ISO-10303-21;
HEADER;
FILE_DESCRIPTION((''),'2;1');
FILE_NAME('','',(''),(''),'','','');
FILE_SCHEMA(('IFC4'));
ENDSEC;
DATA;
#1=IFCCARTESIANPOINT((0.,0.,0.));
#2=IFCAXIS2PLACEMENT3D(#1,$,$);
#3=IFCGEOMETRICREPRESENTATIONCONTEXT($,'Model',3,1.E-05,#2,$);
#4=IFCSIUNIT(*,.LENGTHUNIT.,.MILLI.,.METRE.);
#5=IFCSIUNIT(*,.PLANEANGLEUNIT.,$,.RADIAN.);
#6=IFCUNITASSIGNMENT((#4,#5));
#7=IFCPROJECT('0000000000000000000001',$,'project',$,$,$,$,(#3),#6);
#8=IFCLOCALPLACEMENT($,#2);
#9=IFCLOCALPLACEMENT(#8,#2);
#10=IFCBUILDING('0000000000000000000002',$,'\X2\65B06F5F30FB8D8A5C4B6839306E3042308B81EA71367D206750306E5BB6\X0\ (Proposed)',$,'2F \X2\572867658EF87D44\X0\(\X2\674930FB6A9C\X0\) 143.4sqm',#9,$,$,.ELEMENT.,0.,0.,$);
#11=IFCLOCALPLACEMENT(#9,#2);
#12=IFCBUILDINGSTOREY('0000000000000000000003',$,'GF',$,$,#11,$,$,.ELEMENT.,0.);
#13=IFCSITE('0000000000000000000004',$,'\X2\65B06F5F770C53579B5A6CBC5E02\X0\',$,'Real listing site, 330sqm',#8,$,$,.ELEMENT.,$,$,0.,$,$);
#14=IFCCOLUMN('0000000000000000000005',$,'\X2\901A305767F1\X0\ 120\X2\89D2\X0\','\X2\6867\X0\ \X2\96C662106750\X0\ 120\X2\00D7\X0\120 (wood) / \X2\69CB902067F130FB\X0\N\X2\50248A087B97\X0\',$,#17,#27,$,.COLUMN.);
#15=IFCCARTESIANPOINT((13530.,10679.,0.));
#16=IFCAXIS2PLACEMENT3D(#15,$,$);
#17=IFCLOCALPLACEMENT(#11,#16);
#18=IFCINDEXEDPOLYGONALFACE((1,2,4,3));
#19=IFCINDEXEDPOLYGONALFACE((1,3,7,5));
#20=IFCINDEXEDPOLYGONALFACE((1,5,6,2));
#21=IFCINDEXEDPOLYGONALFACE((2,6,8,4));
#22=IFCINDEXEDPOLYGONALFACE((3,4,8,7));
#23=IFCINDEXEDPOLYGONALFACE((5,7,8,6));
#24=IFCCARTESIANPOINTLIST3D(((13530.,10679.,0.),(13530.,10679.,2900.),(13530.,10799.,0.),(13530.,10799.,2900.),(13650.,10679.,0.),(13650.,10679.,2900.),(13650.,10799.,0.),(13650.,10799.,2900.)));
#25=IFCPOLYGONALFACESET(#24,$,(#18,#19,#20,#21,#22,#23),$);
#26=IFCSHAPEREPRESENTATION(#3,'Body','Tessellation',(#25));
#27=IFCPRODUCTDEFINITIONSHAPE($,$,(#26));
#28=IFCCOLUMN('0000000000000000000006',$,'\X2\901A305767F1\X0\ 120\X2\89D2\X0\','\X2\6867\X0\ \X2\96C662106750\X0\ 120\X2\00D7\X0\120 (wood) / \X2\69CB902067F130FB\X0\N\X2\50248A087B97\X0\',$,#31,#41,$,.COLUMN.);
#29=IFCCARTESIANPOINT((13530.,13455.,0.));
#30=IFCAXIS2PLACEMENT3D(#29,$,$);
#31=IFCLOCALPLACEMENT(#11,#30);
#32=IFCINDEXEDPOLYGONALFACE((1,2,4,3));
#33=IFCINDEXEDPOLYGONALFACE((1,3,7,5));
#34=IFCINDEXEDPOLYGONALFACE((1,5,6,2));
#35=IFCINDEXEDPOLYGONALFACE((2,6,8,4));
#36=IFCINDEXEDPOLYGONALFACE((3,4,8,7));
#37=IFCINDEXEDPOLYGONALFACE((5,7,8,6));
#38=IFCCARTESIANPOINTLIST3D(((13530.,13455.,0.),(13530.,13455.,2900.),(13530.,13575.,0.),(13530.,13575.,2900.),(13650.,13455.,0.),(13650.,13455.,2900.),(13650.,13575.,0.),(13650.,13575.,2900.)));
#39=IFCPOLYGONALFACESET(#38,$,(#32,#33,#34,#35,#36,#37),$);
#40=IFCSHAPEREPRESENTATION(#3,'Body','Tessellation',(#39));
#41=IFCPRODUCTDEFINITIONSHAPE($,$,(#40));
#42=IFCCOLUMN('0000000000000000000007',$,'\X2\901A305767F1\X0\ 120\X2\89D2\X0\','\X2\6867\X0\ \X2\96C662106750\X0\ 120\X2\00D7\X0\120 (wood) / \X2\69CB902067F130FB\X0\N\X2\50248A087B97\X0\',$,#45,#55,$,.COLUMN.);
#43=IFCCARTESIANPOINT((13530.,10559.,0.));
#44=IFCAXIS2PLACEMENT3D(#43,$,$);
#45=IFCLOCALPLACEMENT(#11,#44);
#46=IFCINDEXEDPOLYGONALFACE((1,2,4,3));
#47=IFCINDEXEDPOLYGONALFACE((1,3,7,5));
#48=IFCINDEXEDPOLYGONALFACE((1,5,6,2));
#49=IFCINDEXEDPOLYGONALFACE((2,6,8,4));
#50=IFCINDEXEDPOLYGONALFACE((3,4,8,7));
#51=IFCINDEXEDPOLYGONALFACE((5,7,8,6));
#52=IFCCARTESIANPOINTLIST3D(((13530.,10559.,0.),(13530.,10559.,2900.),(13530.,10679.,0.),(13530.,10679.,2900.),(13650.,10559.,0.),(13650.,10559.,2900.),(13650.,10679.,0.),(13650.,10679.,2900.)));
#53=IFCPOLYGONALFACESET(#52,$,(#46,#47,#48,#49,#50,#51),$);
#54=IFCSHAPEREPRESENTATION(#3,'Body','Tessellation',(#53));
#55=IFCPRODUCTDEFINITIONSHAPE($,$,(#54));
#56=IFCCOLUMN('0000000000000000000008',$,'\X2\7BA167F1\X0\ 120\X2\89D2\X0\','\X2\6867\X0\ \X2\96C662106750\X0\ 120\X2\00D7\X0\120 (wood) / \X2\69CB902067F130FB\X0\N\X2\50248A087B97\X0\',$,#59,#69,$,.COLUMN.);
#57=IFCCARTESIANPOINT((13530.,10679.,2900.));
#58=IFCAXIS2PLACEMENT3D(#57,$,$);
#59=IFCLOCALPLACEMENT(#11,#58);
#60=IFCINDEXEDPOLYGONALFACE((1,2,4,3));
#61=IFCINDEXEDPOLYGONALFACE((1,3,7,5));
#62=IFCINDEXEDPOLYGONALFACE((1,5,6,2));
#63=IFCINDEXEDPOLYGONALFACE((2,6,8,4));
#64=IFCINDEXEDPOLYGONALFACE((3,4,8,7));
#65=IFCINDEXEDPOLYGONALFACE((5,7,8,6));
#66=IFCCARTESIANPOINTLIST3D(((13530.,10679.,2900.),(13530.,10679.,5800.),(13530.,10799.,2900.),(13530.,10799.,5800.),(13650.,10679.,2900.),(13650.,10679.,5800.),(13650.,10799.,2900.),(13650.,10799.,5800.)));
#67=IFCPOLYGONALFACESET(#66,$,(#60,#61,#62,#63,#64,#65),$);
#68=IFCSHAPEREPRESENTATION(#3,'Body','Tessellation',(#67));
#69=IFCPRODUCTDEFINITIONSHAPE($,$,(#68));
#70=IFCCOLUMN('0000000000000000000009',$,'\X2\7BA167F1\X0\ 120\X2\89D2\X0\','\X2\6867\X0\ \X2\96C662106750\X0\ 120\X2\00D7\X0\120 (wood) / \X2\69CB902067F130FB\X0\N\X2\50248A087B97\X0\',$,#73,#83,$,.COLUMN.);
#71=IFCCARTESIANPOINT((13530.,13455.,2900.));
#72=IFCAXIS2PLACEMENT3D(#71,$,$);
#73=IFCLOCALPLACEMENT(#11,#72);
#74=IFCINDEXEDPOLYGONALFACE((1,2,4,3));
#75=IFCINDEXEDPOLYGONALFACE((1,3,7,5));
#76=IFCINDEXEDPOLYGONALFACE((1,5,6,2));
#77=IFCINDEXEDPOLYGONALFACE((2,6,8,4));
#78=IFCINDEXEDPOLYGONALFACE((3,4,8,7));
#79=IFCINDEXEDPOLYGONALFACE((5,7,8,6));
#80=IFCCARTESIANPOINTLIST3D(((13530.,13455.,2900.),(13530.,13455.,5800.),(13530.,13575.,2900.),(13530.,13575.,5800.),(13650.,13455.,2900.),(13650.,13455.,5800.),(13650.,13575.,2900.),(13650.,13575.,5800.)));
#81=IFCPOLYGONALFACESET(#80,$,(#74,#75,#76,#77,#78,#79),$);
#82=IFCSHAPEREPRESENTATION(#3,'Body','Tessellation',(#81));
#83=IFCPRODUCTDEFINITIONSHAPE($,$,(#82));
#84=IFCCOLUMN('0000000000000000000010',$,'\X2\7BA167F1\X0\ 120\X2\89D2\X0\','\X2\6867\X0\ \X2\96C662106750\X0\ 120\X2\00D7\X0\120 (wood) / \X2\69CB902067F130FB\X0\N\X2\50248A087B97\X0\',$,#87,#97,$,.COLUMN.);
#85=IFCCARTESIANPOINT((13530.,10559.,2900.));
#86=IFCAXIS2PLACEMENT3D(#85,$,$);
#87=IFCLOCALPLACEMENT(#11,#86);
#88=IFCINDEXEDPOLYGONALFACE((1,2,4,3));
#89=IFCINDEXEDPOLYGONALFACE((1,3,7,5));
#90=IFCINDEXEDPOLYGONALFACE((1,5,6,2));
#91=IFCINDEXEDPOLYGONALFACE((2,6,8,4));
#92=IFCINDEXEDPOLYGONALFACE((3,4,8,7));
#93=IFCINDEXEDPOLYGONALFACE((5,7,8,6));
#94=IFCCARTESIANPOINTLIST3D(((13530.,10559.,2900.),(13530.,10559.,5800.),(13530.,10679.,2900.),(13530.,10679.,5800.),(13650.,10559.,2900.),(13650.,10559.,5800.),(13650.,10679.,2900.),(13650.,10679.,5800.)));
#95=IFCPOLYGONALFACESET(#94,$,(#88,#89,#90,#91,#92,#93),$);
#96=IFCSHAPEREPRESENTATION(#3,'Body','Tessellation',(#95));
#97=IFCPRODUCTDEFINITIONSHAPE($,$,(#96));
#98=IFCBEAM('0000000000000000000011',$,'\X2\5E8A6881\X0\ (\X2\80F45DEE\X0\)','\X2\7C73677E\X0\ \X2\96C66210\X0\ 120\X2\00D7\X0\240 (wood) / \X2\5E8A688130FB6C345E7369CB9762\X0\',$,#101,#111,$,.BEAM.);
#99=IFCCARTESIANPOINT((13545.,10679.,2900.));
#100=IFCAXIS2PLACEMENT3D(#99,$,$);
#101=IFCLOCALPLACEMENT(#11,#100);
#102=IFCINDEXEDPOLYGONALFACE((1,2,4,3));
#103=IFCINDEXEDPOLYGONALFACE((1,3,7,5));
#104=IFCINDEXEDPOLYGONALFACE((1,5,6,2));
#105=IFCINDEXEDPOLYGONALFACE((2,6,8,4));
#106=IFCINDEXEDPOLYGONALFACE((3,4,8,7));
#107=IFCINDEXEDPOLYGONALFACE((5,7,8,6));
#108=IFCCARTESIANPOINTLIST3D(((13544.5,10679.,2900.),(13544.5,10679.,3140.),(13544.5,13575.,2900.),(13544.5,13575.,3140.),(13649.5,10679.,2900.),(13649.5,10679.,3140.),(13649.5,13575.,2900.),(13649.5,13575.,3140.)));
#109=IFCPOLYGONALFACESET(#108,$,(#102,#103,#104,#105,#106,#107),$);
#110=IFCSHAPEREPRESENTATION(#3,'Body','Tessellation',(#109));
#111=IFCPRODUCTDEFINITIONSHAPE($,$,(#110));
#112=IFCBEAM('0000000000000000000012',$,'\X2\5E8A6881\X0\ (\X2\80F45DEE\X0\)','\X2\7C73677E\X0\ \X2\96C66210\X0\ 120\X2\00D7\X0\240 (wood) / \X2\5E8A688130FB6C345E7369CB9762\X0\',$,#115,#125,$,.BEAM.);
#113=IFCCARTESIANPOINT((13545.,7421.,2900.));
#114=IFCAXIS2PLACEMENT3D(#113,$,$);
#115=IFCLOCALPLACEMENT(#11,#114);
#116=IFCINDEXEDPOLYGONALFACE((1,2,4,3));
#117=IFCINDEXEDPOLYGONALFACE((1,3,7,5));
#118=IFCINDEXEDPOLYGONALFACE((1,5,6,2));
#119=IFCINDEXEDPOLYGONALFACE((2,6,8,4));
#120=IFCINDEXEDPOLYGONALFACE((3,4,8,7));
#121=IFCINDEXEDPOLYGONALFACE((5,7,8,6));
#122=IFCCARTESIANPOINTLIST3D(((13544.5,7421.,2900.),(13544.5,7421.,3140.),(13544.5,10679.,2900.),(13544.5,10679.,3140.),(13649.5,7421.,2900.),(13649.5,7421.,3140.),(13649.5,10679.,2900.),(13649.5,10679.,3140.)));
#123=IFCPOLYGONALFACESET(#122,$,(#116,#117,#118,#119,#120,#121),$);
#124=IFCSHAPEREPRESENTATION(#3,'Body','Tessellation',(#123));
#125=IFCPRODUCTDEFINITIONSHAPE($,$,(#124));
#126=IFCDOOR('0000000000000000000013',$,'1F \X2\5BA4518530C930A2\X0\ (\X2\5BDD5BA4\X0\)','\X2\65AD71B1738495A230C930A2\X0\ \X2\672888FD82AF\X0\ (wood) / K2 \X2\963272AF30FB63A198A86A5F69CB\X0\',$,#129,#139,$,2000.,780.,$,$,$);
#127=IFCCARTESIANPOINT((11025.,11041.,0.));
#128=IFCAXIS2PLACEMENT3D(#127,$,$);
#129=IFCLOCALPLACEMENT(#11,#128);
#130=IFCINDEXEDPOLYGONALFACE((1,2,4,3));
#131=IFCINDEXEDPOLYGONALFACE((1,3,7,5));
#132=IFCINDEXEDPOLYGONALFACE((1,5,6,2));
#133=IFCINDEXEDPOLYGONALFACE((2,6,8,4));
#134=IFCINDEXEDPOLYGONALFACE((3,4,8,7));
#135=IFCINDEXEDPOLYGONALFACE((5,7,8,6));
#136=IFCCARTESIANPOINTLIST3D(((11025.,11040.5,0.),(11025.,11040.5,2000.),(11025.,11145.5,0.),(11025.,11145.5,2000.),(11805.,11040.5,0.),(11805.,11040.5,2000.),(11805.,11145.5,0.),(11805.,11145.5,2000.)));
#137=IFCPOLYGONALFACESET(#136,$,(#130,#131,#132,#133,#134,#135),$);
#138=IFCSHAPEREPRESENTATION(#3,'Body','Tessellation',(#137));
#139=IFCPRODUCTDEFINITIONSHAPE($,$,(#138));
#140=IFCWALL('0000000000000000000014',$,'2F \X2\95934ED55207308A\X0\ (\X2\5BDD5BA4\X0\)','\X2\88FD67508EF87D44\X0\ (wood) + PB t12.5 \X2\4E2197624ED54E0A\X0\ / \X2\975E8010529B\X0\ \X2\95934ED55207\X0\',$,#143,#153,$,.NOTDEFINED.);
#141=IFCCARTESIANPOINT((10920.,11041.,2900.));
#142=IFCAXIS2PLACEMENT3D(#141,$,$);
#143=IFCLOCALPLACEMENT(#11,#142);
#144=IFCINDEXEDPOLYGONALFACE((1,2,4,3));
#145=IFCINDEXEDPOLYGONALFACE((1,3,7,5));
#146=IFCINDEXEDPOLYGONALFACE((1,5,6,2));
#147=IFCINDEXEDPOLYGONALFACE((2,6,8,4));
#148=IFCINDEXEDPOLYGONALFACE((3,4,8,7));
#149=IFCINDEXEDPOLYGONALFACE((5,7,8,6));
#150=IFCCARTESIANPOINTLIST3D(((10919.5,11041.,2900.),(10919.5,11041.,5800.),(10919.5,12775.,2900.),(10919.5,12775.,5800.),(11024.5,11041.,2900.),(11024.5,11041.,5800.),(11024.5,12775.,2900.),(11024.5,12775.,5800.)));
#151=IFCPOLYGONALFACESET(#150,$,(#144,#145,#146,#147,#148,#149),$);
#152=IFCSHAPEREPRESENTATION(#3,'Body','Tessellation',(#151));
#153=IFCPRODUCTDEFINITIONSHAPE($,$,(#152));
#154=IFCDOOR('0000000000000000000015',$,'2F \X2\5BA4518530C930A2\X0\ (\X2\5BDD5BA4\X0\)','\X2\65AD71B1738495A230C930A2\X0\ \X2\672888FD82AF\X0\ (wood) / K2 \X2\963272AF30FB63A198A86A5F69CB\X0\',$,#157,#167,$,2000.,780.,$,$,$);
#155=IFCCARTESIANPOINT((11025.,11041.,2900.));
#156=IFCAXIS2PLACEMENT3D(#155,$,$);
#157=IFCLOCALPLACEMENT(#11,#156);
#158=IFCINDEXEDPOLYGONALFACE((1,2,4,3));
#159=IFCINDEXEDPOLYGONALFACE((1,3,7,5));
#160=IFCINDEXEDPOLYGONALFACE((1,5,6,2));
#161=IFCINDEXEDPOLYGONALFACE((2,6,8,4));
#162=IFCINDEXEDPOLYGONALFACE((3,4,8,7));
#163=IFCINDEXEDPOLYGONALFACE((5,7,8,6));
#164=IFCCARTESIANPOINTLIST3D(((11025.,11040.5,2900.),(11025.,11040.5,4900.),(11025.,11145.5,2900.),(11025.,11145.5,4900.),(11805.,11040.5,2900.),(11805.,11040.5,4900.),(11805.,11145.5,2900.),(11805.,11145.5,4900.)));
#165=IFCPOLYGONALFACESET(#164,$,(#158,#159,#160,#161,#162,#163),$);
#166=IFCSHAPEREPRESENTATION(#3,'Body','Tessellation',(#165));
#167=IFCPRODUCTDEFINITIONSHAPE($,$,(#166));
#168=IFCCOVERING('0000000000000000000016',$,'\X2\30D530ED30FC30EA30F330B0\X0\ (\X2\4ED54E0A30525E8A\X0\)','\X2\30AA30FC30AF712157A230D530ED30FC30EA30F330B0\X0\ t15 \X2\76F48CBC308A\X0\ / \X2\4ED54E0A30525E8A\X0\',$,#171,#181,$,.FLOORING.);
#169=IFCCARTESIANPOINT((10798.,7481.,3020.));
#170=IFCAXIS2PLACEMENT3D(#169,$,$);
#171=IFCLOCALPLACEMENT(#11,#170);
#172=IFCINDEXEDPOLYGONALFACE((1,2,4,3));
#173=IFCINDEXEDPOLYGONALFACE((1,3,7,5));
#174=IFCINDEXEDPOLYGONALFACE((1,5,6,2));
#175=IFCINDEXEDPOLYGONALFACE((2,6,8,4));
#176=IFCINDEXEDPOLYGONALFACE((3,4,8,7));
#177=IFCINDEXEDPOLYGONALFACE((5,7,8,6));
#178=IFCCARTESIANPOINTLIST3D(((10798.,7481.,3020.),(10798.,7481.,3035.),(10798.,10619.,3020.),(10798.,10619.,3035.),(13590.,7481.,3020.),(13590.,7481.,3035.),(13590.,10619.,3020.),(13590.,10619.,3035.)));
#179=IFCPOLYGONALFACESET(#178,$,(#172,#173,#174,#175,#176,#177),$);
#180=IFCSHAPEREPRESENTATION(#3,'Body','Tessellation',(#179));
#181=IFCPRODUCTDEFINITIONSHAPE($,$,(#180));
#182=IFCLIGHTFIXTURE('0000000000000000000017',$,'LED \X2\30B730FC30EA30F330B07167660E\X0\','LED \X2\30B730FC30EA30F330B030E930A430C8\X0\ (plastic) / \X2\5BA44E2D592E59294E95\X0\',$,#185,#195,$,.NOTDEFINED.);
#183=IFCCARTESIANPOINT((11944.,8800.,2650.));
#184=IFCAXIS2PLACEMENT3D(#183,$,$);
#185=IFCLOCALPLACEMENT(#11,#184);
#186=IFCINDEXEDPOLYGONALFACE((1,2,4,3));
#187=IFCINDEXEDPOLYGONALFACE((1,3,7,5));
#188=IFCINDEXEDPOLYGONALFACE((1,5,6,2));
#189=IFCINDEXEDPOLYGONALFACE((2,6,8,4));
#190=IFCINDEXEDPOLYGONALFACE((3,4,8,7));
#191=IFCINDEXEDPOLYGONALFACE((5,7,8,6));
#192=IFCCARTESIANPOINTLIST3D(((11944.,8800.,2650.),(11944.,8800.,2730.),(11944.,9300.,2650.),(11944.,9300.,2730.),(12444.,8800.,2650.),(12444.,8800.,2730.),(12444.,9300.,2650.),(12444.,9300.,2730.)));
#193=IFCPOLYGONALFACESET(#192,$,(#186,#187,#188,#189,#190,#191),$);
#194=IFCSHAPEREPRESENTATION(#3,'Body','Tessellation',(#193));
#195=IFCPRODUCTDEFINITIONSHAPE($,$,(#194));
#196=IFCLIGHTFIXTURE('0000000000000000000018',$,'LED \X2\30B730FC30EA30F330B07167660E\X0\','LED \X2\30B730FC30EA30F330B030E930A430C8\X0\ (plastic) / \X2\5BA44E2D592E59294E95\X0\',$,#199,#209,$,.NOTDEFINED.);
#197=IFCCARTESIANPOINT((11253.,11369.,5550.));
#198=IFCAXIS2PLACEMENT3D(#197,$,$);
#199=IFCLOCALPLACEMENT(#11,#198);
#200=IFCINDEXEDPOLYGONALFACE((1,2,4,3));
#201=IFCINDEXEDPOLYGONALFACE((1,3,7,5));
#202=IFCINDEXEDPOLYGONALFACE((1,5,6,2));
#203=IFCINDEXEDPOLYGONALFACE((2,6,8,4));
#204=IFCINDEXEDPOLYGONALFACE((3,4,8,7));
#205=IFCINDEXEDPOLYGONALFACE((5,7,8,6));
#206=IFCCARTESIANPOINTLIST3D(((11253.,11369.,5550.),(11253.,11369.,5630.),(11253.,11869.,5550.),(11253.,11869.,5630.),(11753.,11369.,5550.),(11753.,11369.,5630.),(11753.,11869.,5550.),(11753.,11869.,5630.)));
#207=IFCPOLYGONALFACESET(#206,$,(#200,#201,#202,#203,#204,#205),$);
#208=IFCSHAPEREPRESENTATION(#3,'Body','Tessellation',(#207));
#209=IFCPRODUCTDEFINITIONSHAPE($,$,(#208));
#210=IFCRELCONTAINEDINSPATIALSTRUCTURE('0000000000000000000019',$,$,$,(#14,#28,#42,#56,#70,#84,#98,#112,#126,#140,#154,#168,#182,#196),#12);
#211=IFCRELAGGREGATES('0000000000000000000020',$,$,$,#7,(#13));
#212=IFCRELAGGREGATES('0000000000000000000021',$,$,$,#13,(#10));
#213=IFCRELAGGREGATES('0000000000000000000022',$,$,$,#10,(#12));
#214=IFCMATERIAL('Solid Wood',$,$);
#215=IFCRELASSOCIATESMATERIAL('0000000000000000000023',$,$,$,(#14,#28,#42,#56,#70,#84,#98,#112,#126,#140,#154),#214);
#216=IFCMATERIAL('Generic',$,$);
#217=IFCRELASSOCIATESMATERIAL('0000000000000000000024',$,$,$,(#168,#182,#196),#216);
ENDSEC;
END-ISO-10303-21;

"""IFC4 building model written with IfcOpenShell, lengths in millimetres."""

from ifc_helpers import new_model, si_unit, frame, frame_2d, origin, place, context, project, spatial, rectangle, extrude, material, element, save


model = new_model("IFC4")

# Units and contexts
model_context = context("Model", 3, precision=1e-05, world=origin())
ifc_project = project(units=[si_unit("LENGTHUNIT", "METRE", prefix="MILLI"), si_unit("PLANEANGLEUNIT", "RADIAN")], contexts=[model_context])

# Site, building, storey
site_placement = place(None, origin())
site = spatial("IfcSite", under=ifc_project, at=site_placement, Name="新潟県南魚沼市", ObjectType="Real listing site, 330sqm", CompositionType="ELEMENT", RefElevation=0.0)
building_placement = place(site_placement, origin())
building = spatial("IfcBuilding", under=site, at=building_placement, Name="新潟・越屋根のある自然素材の家 (Proposed)", ObjectType="2F 在来軸組(杉・檜) 143.4sqm", CompositionType="ELEMENT", ElevationOfRefHeight=0.0, ElevationOfTerrain=0.0)
storey_placement = place(building_placement, origin())
storey = spatial("IfcBuildingStorey", under=building, at=storey_placement, Name="GF", CompositionType="ELEMENT", Elevation=0.0)

# Columns
ifc_material_1 = material(Name="Solid Wood")
column_1_placement = place(storey_placement, frame((13530.0, 10679.0, 0.0)))
element("IfcColumn", 1, at=column_1_placement, inside=storey, material=ifc_material_1, Name="通し柱 120角", Description="桧 集成材 120×120 (wood) / 構造柱・N値計算", PredefinedType="COLUMN", context=model_context, shape_type="SweptSolid", body=[
    extrude(rectangle(XDim=120.0, YDim=120.0, at=frame_2d((60.0, 60.0))), frame((13530.0, 10679.0, 0.0)), (0.0, 0.0, 1.0), 2900.0),
])
column_2_placement = place(storey_placement, frame((13530.0, 13455.0, 0.0)))
element("IfcColumn", 2, at=column_2_placement, inside=storey, material=ifc_material_1, Name="通し柱 120角", Description="桧 集成材 120×120 (wood) / 構造柱・N値計算", PredefinedType="COLUMN", context=model_context, shape_type="SweptSolid", body=[
    extrude(rectangle(XDim=120.0, YDim=120.0, at=frame_2d((60.0, 60.0))), frame((13530.0, 13455.0, 0.0)), (0.0, 0.0, 1.0), 2900.0),
])
column_3_placement = place(storey_placement, frame((13530.0, 10559.0, 0.0)))
element("IfcColumn", 3, at=column_3_placement, inside=storey, material=ifc_material_1, Name="通し柱 120角", Description="桧 集成材 120×120 (wood) / 構造柱・N値計算", PredefinedType="COLUMN", context=model_context, shape_type="SweptSolid", body=[
    extrude(rectangle(XDim=120.0, YDim=120.0, at=frame_2d((60.0, 60.0))), frame((13530.0, 10559.0, 0.0)), (0.0, 0.0, 1.0), 2900.0),
])
column_4_placement = place(storey_placement, frame((13530.0, 10679.0, 2900.0)))
element("IfcColumn", 4, at=column_4_placement, inside=storey, material=ifc_material_1, Name="管柱 120角", Description="桧 集成材 120×120 (wood) / 構造柱・N値計算", PredefinedType="COLUMN", context=model_context, shape_type="SweptSolid", body=[
    extrude(rectangle(XDim=120.0, YDim=120.0, at=frame_2d((60.0, 60.0))), frame((13530.0, 10679.0, 2900.0)), (0.0, 0.0, 1.0), 2900.0),
])
column_5_placement = place(storey_placement, frame((13530.0, 13455.0, 2900.0)))
element("IfcColumn", 5, at=column_5_placement, inside=storey, material=ifc_material_1, Name="管柱 120角", Description="桧 集成材 120×120 (wood) / 構造柱・N値計算", PredefinedType="COLUMN", context=model_context, shape_type="SweptSolid", body=[
    extrude(rectangle(XDim=120.0, YDim=120.0, at=frame_2d((60.0, 60.0))), frame((13530.0, 13455.0, 2900.0)), (0.0, 0.0, 1.0), 2900.0),
])
column_6_placement = place(storey_placement, frame((13530.0, 10559.0, 2900.0)))
element("IfcColumn", 6, at=column_6_placement, inside=storey, material=ifc_material_1, Name="管柱 120角", Description="桧 集成材 120×120 (wood) / 構造柱・N値計算", PredefinedType="COLUMN", context=model_context, shape_type="SweptSolid", body=[
    extrude(rectangle(XDim=120.0, YDim=120.0, at=frame_2d((60.0, 60.0))), frame((13530.0, 10559.0, 2900.0)), (0.0, 0.0, 1.0), 2900.0),
])

# Beams
beam_1_placement = place(storey_placement, frame((13545.0, 10679.0, 2900.0)))
element("IfcBeam", 7, at=beam_1_placement, inside=storey, material=ifc_material_1, Name="床梁 (胴差)", Description="米松 集成 120×240 (wood) / 床梁・水平構面", PredefinedType="BEAM", context=model_context, shape_type="SweptSolid", body=[
    extrude(rectangle(XDim=105.0, YDim=2896.0, at=frame_2d((52.0, 1448.0))), frame((13545.0, 10679.0, 2900.0)), (0.0, 0.0, 1.0), 240.0),
])
beam_2_placement = place(storey_placement, frame((13545.0, 7421.0, 2900.0)))
element("IfcBeam", 8, at=beam_2_placement, inside=storey, material=ifc_material_1, Name="床梁 (胴差)", Description="米松 集成 120×240 (wood) / 床梁・水平構面", PredefinedType="BEAM", context=model_context, shape_type="SweptSolid", body=[
    extrude(rectangle(XDim=105.0, YDim=3258.0, at=frame_2d((52.0, 1629.0))), frame((13545.0, 7421.0, 2900.0)), (0.0, 0.0, 1.0), 240.0),
])

# Door
door_1_placement = place(storey_placement, frame((11025.0, 11041.0, 0.0)))
element("IfcDoor", 9, at=door_1_placement, inside=storey, material=ifc_material_1, Name="1F 室内ドア (寝室)", Description="断熱玄関ドア 木製芯 (wood) / K2 防犯・採風機構", OverallHeight=2000.0, OverallWidth=780.0, context=model_context, shape_type="SweptSolid", body=[
    extrude(rectangle(XDim=780.0, YDim=105.0, at=frame_2d((390.0, 52.0))), frame((11025.0, 11041.0, 0.0)), (0.0, 0.0, 1.0), 2000.0),
])

# Wall
wall_1_placement = place(storey_placement, frame((10920.0, 11041.0, 2900.0)))
element("IfcWall", 10, at=wall_1_placement, inside=storey, material=ifc_material_1, Name="2F 間仕切り (寝室)", Description="製材軸組 (wood) + PB t12.5 両面仕上 / 非耐力 間仕切", PredefinedType="NOTDEFINED", context=model_context, shape_type="SweptSolid", body=[
    extrude(rectangle(XDim=105.0, YDim=1734.0, at=frame_2d((52.0, 867.0))), frame((10920.0, 11041.0, 2900.0)), (0.0, 0.0, 1.0), 2900.0),
])

# Door
door_2_placement = place(storey_placement, frame((11025.0, 11041.0, 2900.0)))
element("IfcDoor", 11, at=door_2_placement, inside=storey, material=ifc_material_1, Name="2F 室内ドア (寝室)", Description="断熱玄関ドア 木製芯 (wood) / K2 防犯・採風機構", OverallHeight=2000.0, OverallWidth=780.0, context=model_context, shape_type="SweptSolid", body=[
    extrude(rectangle(XDim=780.0, YDim=105.0, at=frame_2d((390.0, 52.0))), frame((11025.0, 11041.0, 2900.0)), (0.0, 0.0, 1.0), 2000.0),
])

# Covering
ifc_material_2 = material(Name="Generic")
covering_placement = place(storey_placement, frame((10798.0, 7481.0, 3020.0)))
element("IfcCovering", 12, at=covering_placement, inside=storey, material=ifc_material_2, Name="フローリング (仕上げ床)", Description="オーク無垢フローリング t15 直貼り / 仕上げ床", PredefinedType="FLOORING", context=model_context, shape_type="SweptSolid", body=[
    extrude(rectangle(XDim=2792.0, YDim=3138.0, at=frame_2d((1396.0, 1569.0))), frame((10798.0, 7481.0, 3020.0)), (0.0, 0.0, 1.0), 15.0),
])

# Light fixtures
light_fixture_1_placement = place(storey_placement, frame((11944.0, 8800.0, 2650.0)))
element("IfcLightFixture", 13, at=light_fixture_1_placement, inside=storey, material=ifc_material_2, Name="LED シーリング照明", Description="LED シーリングライト (plastic) / 室中央天井", PredefinedType="NOTDEFINED", context=model_context, shape_type="SweptSolid", body=[
    extrude(rectangle(XDim=500.0, YDim=500.0, at=frame_2d((250.0, 250.0))), frame((11944.0, 8800.0, 2650.0)), (0.0, 0.0, 1.0), 80.0),
])
light_fixture_2_placement = place(storey_placement, frame((11253.0, 11369.0, 5550.0)))
element("IfcLightFixture", 14, at=light_fixture_2_placement, inside=storey, material=ifc_material_2, Name="LED シーリング照明", Description="LED シーリングライト (plastic) / 室中央天井", PredefinedType="NOTDEFINED", context=model_context, shape_type="SweptSolid", body=[
    extrude(rectangle(XDim=500.0, YDim=500.0, at=frame_2d((250.0, 250.0))), frame((11253.0, 11369.0, 5550.0)), (0.0, 0.0, 1.0), 80.0),
])

save(model, "model.ifc")
